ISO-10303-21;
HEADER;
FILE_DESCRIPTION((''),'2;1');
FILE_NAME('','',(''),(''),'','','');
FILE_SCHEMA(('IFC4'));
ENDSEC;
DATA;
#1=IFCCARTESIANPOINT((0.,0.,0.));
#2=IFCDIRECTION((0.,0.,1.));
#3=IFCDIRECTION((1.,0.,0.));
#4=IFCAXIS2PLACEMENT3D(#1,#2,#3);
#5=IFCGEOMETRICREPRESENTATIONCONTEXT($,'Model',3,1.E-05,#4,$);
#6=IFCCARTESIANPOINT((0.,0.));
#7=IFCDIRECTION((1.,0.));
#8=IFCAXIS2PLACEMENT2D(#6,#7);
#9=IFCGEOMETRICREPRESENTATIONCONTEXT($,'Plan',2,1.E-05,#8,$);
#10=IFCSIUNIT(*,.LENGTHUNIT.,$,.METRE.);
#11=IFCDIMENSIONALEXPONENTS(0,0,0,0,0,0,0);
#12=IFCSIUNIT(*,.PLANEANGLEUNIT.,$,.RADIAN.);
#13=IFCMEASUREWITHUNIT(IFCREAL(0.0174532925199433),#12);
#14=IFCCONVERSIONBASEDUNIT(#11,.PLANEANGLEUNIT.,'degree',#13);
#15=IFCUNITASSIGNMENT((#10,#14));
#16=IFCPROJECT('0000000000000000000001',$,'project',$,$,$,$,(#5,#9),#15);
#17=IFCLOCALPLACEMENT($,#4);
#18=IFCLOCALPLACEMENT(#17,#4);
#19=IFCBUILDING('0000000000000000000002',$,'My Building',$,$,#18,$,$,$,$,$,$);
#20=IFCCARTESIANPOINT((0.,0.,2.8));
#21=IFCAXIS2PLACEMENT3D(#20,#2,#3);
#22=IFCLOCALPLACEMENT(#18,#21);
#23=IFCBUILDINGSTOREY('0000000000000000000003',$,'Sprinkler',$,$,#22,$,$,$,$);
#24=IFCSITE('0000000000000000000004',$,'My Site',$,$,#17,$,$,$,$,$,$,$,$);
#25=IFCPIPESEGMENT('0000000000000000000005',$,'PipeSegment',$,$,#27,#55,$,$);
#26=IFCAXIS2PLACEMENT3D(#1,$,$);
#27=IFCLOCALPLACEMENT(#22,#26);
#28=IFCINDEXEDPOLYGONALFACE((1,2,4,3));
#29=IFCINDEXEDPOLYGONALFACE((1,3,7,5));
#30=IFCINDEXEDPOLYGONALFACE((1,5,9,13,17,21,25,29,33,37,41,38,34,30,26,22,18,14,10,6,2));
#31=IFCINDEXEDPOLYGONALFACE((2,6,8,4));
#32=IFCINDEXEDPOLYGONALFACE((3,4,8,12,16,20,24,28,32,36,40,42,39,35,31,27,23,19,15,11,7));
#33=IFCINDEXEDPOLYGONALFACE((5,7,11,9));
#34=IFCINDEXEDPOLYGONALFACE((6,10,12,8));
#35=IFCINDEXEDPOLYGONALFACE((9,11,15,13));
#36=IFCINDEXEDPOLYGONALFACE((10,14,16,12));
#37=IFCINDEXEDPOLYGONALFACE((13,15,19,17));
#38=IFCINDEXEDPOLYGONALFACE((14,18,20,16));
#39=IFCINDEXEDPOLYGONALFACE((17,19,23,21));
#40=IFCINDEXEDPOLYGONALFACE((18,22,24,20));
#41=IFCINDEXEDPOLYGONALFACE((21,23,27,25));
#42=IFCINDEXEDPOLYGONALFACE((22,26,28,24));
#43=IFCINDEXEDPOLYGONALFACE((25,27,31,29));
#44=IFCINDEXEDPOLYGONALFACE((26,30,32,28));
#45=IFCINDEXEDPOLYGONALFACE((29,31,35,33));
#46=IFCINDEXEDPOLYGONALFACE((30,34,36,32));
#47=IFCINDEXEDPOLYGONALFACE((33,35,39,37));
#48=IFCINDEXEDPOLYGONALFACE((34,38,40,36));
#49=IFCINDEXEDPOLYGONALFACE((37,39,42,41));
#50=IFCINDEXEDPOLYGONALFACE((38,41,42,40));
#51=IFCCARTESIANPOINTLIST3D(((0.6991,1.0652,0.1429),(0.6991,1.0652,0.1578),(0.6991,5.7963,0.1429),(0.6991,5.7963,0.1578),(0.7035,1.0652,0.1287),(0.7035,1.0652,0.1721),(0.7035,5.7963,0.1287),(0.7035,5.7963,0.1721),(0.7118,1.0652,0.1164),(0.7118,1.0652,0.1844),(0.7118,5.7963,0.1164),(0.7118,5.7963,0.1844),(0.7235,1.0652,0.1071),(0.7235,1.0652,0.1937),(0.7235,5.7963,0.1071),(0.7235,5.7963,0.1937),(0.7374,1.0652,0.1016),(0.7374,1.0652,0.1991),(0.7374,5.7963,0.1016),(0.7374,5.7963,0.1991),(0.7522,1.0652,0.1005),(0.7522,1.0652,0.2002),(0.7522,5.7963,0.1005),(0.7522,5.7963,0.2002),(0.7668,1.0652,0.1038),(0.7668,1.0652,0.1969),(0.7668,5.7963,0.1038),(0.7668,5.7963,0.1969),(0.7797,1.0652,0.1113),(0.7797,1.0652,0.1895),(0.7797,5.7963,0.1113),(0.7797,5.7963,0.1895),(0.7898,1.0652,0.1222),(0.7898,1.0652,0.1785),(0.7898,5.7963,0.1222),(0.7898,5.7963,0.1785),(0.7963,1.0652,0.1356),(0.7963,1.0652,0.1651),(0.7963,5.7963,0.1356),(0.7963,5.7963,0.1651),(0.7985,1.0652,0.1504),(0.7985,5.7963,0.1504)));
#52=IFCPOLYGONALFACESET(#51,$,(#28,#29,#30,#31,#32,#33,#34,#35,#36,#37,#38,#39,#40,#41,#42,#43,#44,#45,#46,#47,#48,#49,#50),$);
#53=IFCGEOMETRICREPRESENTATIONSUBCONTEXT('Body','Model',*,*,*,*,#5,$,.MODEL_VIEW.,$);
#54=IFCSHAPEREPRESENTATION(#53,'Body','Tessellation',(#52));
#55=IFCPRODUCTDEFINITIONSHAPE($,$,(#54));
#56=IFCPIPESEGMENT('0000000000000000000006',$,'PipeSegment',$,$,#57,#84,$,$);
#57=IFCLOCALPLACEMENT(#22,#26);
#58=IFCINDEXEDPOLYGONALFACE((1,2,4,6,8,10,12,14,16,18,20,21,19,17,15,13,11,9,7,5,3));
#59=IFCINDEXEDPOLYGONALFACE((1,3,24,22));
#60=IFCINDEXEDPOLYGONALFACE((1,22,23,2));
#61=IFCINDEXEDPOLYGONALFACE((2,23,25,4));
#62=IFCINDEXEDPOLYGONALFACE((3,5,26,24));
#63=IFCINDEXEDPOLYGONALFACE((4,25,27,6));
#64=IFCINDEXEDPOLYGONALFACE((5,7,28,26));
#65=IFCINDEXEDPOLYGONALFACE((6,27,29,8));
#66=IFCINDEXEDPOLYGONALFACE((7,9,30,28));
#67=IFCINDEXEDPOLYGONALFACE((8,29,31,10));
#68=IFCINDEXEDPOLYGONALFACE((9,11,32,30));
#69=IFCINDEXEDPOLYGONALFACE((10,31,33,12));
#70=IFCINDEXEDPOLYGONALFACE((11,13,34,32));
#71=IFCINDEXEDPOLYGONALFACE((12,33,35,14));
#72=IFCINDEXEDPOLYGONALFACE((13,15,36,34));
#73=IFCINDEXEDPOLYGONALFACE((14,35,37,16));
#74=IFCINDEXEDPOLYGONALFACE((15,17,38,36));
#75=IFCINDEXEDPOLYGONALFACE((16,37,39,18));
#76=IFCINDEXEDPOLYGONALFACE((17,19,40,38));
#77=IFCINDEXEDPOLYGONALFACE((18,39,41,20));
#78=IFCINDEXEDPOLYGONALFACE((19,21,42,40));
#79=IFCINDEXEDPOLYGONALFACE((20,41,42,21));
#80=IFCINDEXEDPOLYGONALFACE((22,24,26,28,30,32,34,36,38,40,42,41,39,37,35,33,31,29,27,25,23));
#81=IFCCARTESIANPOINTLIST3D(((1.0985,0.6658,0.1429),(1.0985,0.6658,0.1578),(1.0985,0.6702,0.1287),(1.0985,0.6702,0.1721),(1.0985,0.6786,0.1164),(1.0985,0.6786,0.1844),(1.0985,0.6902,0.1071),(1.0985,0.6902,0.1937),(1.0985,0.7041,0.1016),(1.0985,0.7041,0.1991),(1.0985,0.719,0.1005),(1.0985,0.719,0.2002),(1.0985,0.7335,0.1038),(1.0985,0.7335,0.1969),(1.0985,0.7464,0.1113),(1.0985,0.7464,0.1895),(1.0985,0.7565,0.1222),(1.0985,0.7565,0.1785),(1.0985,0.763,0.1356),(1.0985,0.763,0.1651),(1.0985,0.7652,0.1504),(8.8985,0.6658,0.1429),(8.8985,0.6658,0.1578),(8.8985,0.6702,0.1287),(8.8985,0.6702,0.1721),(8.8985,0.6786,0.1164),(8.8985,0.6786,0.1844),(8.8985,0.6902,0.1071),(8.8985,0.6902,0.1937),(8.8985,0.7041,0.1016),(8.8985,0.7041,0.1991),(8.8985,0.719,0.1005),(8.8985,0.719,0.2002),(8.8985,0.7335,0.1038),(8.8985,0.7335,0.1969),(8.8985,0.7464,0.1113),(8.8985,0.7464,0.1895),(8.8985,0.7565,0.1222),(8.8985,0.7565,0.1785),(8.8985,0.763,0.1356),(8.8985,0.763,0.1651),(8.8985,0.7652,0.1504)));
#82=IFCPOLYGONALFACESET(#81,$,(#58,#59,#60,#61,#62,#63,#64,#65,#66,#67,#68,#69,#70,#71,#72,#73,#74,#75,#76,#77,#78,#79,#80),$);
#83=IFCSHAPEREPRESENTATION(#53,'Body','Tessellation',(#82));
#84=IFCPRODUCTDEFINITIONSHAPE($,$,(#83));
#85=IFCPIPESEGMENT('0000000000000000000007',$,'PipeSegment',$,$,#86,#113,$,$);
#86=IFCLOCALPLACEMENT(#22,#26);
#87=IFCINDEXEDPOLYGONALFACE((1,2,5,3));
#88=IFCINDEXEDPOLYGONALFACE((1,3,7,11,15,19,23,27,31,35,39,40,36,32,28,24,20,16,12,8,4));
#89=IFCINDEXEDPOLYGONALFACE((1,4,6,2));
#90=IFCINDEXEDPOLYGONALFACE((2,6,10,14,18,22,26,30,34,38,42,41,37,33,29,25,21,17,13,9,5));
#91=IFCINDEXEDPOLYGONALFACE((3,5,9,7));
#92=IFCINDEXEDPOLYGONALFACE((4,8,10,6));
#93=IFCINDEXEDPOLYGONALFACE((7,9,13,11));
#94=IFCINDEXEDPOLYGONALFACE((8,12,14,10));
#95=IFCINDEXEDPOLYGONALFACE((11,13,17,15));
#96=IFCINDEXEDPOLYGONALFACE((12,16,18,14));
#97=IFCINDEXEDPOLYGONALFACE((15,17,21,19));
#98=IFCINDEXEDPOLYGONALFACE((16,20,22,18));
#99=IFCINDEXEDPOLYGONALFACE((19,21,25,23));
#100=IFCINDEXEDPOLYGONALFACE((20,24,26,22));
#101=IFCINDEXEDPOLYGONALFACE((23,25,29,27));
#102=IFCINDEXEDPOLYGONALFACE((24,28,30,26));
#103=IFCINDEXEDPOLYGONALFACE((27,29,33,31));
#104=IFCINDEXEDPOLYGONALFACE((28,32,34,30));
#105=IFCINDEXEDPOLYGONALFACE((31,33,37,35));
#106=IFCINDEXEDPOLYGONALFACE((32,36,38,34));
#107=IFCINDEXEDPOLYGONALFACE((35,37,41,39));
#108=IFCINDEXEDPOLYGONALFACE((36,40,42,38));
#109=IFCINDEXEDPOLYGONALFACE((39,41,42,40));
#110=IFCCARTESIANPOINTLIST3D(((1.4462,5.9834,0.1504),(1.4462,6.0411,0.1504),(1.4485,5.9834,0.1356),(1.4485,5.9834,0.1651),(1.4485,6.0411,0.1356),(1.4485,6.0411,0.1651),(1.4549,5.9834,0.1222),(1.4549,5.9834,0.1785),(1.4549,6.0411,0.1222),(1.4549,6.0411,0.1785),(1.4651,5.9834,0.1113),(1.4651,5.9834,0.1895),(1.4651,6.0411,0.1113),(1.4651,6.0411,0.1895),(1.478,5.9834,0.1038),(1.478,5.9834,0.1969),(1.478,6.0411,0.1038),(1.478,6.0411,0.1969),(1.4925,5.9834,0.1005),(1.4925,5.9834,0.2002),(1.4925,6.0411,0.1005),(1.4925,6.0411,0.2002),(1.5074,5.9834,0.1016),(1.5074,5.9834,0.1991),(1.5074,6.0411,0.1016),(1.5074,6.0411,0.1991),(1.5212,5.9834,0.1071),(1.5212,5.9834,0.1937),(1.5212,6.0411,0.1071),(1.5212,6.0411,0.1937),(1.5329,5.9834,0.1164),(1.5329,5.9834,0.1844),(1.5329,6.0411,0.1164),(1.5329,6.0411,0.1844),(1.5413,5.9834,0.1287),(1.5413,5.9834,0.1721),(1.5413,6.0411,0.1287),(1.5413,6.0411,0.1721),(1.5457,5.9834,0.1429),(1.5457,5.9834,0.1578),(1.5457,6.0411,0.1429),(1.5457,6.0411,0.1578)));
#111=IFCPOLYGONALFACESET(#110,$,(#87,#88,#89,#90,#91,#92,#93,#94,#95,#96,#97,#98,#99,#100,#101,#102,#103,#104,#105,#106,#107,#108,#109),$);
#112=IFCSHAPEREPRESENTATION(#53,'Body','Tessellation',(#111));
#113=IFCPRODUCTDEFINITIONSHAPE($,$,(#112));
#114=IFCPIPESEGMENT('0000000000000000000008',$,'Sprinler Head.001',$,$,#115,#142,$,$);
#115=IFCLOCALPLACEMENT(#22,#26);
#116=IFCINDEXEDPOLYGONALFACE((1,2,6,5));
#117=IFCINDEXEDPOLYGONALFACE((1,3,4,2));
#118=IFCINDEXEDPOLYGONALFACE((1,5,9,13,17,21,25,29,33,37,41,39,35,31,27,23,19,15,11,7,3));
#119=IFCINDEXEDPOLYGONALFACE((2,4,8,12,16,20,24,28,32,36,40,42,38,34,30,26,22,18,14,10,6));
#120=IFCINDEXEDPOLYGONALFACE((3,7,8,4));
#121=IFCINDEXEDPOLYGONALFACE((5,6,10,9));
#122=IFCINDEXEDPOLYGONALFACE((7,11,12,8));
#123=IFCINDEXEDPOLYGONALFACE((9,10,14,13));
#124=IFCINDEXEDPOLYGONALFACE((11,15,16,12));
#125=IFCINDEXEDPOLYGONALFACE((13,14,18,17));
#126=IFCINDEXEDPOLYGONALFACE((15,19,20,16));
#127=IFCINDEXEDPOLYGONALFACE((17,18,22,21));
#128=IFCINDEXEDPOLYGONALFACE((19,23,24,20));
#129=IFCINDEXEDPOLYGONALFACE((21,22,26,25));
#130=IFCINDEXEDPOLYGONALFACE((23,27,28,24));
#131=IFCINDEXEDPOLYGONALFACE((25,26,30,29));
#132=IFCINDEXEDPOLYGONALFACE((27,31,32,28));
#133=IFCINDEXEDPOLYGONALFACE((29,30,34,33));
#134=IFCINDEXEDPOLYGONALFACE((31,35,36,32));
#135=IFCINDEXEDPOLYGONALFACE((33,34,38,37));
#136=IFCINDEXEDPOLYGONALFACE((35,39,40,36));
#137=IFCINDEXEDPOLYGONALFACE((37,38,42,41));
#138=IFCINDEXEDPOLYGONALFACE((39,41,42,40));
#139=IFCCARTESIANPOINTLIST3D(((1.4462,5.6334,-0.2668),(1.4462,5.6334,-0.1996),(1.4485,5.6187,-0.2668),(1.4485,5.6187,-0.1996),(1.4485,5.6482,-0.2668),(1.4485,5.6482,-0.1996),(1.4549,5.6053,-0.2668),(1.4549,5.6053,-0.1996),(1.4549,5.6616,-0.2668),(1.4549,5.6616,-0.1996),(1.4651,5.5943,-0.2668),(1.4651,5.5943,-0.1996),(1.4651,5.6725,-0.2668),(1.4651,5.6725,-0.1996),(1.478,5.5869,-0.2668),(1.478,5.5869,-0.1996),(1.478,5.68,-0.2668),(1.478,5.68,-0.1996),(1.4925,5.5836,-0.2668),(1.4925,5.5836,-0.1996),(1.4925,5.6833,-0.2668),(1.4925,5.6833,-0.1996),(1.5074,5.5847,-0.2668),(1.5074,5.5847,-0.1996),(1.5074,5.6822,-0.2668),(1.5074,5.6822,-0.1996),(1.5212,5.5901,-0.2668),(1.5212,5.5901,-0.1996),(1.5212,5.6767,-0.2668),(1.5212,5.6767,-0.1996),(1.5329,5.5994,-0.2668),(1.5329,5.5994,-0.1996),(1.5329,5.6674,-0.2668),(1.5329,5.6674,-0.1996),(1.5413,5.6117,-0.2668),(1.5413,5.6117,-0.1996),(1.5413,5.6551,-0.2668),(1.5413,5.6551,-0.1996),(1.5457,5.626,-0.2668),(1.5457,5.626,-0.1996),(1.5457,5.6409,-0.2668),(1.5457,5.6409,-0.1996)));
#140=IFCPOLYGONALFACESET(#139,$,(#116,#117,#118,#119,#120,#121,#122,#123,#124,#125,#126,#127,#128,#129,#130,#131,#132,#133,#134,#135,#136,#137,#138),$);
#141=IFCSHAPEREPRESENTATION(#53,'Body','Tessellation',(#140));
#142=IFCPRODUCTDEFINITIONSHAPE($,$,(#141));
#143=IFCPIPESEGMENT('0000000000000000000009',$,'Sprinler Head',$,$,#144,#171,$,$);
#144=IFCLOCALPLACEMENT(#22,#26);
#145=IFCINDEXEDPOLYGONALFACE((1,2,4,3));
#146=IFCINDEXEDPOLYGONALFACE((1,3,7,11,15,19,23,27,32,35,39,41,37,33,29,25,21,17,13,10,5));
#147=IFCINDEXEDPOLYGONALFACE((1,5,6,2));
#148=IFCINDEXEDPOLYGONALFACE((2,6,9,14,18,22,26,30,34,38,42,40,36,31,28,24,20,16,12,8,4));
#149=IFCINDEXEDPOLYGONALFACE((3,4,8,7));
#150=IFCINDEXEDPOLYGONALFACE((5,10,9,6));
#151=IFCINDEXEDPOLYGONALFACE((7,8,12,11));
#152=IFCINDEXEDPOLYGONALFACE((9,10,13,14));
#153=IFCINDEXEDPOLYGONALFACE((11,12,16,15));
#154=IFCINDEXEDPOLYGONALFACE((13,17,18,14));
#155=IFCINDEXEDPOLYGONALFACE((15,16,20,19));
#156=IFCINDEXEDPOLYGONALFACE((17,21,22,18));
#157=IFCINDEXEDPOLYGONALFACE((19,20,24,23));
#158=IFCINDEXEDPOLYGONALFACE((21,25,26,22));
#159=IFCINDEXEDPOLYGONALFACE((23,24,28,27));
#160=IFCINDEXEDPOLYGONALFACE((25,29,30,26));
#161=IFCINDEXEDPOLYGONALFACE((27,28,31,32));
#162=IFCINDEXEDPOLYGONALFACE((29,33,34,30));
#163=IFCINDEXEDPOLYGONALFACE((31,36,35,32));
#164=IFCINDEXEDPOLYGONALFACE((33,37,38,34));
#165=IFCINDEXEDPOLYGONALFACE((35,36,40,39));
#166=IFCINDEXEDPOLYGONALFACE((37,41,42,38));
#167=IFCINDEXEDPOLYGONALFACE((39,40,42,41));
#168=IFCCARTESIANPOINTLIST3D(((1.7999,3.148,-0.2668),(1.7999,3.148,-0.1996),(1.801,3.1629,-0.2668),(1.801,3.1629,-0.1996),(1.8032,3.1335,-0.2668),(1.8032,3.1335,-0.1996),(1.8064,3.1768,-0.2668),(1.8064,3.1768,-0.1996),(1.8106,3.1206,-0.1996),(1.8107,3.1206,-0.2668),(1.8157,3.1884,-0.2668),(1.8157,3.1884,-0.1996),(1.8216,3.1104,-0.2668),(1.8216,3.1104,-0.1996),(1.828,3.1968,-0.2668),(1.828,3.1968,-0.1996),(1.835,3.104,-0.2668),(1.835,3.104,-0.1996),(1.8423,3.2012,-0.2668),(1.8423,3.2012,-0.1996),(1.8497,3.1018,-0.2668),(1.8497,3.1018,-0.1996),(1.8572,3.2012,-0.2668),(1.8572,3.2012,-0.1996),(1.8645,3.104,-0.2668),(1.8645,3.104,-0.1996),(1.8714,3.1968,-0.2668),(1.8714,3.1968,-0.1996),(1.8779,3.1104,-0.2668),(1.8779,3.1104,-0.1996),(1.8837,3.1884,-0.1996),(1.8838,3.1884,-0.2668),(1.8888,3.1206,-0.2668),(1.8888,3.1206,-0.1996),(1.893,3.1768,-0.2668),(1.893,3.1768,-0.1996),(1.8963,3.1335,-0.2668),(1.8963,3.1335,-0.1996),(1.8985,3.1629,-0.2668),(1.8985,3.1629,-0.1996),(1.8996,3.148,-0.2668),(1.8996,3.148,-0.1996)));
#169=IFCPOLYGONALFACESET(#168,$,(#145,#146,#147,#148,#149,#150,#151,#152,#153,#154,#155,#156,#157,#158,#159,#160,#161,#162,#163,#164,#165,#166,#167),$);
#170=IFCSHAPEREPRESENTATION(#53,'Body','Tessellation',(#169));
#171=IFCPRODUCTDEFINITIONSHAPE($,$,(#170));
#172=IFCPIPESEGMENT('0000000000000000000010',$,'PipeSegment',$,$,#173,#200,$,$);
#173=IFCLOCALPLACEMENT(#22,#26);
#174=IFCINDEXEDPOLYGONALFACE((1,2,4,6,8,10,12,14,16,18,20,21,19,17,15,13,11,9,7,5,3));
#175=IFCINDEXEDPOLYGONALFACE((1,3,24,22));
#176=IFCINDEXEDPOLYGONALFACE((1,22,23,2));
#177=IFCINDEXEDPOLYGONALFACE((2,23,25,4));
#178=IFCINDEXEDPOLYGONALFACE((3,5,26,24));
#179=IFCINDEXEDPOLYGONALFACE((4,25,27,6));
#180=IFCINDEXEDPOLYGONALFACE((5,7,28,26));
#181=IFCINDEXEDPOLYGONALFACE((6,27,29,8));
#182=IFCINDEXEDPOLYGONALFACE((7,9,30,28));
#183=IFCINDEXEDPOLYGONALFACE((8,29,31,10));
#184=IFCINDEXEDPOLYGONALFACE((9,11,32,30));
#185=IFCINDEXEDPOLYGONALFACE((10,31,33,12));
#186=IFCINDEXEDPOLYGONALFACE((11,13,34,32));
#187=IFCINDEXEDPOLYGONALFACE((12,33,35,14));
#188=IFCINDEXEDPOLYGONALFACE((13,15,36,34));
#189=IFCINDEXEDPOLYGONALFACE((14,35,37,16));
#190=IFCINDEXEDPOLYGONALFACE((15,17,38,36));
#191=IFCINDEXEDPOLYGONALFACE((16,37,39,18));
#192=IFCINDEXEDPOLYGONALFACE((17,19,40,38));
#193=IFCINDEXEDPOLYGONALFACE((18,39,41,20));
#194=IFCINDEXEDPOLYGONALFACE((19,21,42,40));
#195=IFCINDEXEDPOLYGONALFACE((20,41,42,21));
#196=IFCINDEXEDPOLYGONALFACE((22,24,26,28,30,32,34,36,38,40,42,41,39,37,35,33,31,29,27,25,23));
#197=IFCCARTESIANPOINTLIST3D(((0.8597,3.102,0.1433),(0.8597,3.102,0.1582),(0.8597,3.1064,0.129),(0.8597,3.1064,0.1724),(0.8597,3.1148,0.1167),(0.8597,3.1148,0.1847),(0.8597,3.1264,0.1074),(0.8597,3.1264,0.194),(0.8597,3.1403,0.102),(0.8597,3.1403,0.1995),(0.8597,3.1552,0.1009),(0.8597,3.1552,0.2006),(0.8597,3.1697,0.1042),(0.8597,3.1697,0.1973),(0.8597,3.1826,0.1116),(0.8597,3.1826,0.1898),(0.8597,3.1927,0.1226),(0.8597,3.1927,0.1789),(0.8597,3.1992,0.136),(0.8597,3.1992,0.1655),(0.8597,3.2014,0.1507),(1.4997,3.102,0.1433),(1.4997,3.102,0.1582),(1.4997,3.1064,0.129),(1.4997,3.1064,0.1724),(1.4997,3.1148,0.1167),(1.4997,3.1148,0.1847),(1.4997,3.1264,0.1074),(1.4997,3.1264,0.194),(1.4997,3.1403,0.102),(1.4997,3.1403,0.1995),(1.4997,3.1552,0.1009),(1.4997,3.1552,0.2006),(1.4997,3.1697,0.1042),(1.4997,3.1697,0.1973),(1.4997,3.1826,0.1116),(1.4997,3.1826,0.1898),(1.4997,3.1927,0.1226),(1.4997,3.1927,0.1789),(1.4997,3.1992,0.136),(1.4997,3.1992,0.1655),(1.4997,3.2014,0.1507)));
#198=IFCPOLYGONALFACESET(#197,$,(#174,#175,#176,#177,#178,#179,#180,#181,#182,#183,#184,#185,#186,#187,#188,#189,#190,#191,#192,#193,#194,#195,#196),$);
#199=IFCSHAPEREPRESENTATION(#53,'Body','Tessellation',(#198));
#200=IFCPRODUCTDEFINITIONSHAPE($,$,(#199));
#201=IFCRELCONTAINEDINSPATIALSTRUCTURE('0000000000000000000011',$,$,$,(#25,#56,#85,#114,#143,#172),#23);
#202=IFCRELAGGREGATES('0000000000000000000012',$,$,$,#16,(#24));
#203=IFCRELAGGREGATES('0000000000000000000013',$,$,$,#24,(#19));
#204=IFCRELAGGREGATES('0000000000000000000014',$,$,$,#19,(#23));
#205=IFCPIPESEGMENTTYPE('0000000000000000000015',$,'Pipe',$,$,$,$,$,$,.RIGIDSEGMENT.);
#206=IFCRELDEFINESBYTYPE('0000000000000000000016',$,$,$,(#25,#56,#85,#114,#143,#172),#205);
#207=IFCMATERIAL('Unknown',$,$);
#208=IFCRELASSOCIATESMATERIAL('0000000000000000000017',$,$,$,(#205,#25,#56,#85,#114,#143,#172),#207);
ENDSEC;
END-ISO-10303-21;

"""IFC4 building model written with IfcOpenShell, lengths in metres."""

from ifc_helpers import new_model, entity, si_unit, converted_unit, frame, origin_with_axes, origin_2d_with_axis, place, context, subcontext, project, spatial, circle, extrude, material, material_profile, profile_set, profile_usage, type_object, element, save


model = new_model("IFC4")

# Units and contexts
model_context = context("Model", 3, precision=1e-05, world=origin_with_axes())
plan_context = context("Plan", 2, precision=1e-05, world=origin_2d_with_axis())
body_context = subcontext(model_context, "Body", "Model", "MODEL_VIEW")
ifc_project = project(units=[si_unit("LENGTHUNIT", "METRE"), converted_unit("PLANEANGLEUNIT", "degree", entity("IfcReal", 0.0174532925199433), si_unit("PLANEANGLEUNIT", "RADIAN"), dimensions=[0, 0, 0, 0, 0, 0, 0])], contexts=[model_context, plan_context])

# Site, building, storey
site_placement = place(None, origin_with_axes())
site = spatial("IfcSite", under=ifc_project, at=site_placement, Name="My Site")
building_placement = place(site_placement, origin_with_axes())
building = spatial("IfcBuilding", under=site, at=building_placement, Name="My Building")
storey_placement = place(building_placement, frame((0.0, 0.0, 2.8), z_axis=(0.0, 0.0, 1.0), x_axis=(1.0, 0.0, 0.0)))
storey = spatial("IfcBuildingStorey", under=building, at=storey_placement, Name="Sprinkler")

# Pipe segments
ifc_material = material(Name="Unknown")
ifc_material_profile_1 = material_profile(ifc_material, circle(Radius=0.05))
ifc_profile_set_1 = profile_set([ifc_material_profile_1])
ifc_profile_usage_1 = profile_usage(ifc_profile_set_1, cardinal=5)
pipe_segment_type = type_object("IfcPipeSegmentType", Name="Pipe", PredefinedType="RIGIDSEGMENT", material=ifc_profile_set_1)
pipe_segment_1_placement = place(storey_placement, frame((0.7485, 5.7963, 0.1504), z_axis=(0.0, -1.0, 0.0), x_axis=(1.0, 0.0, 0.0)))
element("IfcPipeSegment", 1, at=pipe_segment_1_placement, inside=storey, type_object=pipe_segment_type, material=ifc_profile_usage_1, Name="PipeSegment", context=body_context, shape_type="SweptSolid", body=[
    extrude(circle(Radius=0.05), origin_with_axes(), (0.0, 0.0, 1.0), 4.7311),
])
ifc_profile_usage_2 = profile_usage(ifc_profile_set_1, cardinal=5)
pipe_segment_2_placement = place(storey_placement, frame((1.0985, 0.7152, 0.1504), z_axis=(1.0, 0.0, 0.0), x_axis=(0.0, 1.0, 0.0)))
element("IfcPipeSegment", 2, at=pipe_segment_2_placement, inside=storey, type_object=pipe_segment_type, material=ifc_profile_usage_2, Name="PipeSegment", context=body_context, shape_type="SweptSolid", body=[
    extrude(circle(Radius=0.05), origin_with_axes(), (0.0, 0.0, 1.0), 7.8),
])
ifc_profile_usage_3 = profile_usage(ifc_profile_set_1, cardinal=5)
pipe_segment_3_placement = place(storey_placement, frame((1.4962, 5.9834, 0.1504), z_axis=(0.0, 1.0, -0.000008), x_axis=(-1.0, 0.0, 0.0)))
element("IfcPipeSegment", 3, at=pipe_segment_3_placement, inside=storey, type_object=pipe_segment_type, material=ifc_profile_usage_3, Name="PipeSegment", context=body_context, shape_type="SweptSolid", body=[
    extrude(circle(Radius=0.05), origin_with_axes(), (0.0, 0.0, 1.0), 0.0577),
])
ifc_profile_usage_4 = profile_usage(ifc_profile_set_1, cardinal=5)
pipe_segment_4_placement = place(storey_placement, frame((1.4962, 5.6334, -0.2668), z_axis=(0.0, 0.000008, 1.0), x_axis=(-1.0, 0.0, 0.0)))
element("IfcPipeSegment", 4, at=pipe_segment_4_placement, inside=storey, type_object=pipe_segment_type, material=ifc_profile_usage_4, Name="Sprinler Head.001", context=body_context, shape_type="SweptSolid", body=[
    extrude(circle(Radius=0.05), origin_with_axes(), (0.0, 0.0, 1.0), 0.0672),
])
ifc_profile_usage_5 = profile_usage(ifc_profile_set_1, cardinal=5)
pipe_segment_5_placement = place(storey_placement, frame((1.8497, 3.1518, -0.2668), z_axis=(-0.000008, 0.0, 1.0), x_axis=(0.0, -1.0, 0.0)))
element("IfcPipeSegment", 5, at=pipe_segment_5_placement, inside=storey, type_object=pipe_segment_type, material=ifc_profile_usage_5, Name="Sprinler Head", context=body_context, shape_type="SweptSolid", body=[
    extrude(circle(Radius=0.05), origin_with_axes(), (0.0, 0.0, 1.0), 0.0672),
])
ifc_profile_usage_6 = profile_usage(ifc_profile_set_1, cardinal=5)
pipe_segment_6_placement = place(storey_placement, frame((0.8597, 3.1514, 0.1507), z_axis=(1.0, 0.0, 0.0), x_axis=(0.0, 1.0, 0.0)))
element("IfcPipeSegment", 6, at=pipe_segment_6_placement, inside=storey, type_object=pipe_segment_type, material=ifc_profile_usage_6, Name="PipeSegment", context=body_context, shape_type="SweptSolid", body=[
    extrude(circle(Radius=0.05), origin_with_axes(), (0.0, 0.0, 1.0), 0.64),
])

save(model, "model.ifc")
